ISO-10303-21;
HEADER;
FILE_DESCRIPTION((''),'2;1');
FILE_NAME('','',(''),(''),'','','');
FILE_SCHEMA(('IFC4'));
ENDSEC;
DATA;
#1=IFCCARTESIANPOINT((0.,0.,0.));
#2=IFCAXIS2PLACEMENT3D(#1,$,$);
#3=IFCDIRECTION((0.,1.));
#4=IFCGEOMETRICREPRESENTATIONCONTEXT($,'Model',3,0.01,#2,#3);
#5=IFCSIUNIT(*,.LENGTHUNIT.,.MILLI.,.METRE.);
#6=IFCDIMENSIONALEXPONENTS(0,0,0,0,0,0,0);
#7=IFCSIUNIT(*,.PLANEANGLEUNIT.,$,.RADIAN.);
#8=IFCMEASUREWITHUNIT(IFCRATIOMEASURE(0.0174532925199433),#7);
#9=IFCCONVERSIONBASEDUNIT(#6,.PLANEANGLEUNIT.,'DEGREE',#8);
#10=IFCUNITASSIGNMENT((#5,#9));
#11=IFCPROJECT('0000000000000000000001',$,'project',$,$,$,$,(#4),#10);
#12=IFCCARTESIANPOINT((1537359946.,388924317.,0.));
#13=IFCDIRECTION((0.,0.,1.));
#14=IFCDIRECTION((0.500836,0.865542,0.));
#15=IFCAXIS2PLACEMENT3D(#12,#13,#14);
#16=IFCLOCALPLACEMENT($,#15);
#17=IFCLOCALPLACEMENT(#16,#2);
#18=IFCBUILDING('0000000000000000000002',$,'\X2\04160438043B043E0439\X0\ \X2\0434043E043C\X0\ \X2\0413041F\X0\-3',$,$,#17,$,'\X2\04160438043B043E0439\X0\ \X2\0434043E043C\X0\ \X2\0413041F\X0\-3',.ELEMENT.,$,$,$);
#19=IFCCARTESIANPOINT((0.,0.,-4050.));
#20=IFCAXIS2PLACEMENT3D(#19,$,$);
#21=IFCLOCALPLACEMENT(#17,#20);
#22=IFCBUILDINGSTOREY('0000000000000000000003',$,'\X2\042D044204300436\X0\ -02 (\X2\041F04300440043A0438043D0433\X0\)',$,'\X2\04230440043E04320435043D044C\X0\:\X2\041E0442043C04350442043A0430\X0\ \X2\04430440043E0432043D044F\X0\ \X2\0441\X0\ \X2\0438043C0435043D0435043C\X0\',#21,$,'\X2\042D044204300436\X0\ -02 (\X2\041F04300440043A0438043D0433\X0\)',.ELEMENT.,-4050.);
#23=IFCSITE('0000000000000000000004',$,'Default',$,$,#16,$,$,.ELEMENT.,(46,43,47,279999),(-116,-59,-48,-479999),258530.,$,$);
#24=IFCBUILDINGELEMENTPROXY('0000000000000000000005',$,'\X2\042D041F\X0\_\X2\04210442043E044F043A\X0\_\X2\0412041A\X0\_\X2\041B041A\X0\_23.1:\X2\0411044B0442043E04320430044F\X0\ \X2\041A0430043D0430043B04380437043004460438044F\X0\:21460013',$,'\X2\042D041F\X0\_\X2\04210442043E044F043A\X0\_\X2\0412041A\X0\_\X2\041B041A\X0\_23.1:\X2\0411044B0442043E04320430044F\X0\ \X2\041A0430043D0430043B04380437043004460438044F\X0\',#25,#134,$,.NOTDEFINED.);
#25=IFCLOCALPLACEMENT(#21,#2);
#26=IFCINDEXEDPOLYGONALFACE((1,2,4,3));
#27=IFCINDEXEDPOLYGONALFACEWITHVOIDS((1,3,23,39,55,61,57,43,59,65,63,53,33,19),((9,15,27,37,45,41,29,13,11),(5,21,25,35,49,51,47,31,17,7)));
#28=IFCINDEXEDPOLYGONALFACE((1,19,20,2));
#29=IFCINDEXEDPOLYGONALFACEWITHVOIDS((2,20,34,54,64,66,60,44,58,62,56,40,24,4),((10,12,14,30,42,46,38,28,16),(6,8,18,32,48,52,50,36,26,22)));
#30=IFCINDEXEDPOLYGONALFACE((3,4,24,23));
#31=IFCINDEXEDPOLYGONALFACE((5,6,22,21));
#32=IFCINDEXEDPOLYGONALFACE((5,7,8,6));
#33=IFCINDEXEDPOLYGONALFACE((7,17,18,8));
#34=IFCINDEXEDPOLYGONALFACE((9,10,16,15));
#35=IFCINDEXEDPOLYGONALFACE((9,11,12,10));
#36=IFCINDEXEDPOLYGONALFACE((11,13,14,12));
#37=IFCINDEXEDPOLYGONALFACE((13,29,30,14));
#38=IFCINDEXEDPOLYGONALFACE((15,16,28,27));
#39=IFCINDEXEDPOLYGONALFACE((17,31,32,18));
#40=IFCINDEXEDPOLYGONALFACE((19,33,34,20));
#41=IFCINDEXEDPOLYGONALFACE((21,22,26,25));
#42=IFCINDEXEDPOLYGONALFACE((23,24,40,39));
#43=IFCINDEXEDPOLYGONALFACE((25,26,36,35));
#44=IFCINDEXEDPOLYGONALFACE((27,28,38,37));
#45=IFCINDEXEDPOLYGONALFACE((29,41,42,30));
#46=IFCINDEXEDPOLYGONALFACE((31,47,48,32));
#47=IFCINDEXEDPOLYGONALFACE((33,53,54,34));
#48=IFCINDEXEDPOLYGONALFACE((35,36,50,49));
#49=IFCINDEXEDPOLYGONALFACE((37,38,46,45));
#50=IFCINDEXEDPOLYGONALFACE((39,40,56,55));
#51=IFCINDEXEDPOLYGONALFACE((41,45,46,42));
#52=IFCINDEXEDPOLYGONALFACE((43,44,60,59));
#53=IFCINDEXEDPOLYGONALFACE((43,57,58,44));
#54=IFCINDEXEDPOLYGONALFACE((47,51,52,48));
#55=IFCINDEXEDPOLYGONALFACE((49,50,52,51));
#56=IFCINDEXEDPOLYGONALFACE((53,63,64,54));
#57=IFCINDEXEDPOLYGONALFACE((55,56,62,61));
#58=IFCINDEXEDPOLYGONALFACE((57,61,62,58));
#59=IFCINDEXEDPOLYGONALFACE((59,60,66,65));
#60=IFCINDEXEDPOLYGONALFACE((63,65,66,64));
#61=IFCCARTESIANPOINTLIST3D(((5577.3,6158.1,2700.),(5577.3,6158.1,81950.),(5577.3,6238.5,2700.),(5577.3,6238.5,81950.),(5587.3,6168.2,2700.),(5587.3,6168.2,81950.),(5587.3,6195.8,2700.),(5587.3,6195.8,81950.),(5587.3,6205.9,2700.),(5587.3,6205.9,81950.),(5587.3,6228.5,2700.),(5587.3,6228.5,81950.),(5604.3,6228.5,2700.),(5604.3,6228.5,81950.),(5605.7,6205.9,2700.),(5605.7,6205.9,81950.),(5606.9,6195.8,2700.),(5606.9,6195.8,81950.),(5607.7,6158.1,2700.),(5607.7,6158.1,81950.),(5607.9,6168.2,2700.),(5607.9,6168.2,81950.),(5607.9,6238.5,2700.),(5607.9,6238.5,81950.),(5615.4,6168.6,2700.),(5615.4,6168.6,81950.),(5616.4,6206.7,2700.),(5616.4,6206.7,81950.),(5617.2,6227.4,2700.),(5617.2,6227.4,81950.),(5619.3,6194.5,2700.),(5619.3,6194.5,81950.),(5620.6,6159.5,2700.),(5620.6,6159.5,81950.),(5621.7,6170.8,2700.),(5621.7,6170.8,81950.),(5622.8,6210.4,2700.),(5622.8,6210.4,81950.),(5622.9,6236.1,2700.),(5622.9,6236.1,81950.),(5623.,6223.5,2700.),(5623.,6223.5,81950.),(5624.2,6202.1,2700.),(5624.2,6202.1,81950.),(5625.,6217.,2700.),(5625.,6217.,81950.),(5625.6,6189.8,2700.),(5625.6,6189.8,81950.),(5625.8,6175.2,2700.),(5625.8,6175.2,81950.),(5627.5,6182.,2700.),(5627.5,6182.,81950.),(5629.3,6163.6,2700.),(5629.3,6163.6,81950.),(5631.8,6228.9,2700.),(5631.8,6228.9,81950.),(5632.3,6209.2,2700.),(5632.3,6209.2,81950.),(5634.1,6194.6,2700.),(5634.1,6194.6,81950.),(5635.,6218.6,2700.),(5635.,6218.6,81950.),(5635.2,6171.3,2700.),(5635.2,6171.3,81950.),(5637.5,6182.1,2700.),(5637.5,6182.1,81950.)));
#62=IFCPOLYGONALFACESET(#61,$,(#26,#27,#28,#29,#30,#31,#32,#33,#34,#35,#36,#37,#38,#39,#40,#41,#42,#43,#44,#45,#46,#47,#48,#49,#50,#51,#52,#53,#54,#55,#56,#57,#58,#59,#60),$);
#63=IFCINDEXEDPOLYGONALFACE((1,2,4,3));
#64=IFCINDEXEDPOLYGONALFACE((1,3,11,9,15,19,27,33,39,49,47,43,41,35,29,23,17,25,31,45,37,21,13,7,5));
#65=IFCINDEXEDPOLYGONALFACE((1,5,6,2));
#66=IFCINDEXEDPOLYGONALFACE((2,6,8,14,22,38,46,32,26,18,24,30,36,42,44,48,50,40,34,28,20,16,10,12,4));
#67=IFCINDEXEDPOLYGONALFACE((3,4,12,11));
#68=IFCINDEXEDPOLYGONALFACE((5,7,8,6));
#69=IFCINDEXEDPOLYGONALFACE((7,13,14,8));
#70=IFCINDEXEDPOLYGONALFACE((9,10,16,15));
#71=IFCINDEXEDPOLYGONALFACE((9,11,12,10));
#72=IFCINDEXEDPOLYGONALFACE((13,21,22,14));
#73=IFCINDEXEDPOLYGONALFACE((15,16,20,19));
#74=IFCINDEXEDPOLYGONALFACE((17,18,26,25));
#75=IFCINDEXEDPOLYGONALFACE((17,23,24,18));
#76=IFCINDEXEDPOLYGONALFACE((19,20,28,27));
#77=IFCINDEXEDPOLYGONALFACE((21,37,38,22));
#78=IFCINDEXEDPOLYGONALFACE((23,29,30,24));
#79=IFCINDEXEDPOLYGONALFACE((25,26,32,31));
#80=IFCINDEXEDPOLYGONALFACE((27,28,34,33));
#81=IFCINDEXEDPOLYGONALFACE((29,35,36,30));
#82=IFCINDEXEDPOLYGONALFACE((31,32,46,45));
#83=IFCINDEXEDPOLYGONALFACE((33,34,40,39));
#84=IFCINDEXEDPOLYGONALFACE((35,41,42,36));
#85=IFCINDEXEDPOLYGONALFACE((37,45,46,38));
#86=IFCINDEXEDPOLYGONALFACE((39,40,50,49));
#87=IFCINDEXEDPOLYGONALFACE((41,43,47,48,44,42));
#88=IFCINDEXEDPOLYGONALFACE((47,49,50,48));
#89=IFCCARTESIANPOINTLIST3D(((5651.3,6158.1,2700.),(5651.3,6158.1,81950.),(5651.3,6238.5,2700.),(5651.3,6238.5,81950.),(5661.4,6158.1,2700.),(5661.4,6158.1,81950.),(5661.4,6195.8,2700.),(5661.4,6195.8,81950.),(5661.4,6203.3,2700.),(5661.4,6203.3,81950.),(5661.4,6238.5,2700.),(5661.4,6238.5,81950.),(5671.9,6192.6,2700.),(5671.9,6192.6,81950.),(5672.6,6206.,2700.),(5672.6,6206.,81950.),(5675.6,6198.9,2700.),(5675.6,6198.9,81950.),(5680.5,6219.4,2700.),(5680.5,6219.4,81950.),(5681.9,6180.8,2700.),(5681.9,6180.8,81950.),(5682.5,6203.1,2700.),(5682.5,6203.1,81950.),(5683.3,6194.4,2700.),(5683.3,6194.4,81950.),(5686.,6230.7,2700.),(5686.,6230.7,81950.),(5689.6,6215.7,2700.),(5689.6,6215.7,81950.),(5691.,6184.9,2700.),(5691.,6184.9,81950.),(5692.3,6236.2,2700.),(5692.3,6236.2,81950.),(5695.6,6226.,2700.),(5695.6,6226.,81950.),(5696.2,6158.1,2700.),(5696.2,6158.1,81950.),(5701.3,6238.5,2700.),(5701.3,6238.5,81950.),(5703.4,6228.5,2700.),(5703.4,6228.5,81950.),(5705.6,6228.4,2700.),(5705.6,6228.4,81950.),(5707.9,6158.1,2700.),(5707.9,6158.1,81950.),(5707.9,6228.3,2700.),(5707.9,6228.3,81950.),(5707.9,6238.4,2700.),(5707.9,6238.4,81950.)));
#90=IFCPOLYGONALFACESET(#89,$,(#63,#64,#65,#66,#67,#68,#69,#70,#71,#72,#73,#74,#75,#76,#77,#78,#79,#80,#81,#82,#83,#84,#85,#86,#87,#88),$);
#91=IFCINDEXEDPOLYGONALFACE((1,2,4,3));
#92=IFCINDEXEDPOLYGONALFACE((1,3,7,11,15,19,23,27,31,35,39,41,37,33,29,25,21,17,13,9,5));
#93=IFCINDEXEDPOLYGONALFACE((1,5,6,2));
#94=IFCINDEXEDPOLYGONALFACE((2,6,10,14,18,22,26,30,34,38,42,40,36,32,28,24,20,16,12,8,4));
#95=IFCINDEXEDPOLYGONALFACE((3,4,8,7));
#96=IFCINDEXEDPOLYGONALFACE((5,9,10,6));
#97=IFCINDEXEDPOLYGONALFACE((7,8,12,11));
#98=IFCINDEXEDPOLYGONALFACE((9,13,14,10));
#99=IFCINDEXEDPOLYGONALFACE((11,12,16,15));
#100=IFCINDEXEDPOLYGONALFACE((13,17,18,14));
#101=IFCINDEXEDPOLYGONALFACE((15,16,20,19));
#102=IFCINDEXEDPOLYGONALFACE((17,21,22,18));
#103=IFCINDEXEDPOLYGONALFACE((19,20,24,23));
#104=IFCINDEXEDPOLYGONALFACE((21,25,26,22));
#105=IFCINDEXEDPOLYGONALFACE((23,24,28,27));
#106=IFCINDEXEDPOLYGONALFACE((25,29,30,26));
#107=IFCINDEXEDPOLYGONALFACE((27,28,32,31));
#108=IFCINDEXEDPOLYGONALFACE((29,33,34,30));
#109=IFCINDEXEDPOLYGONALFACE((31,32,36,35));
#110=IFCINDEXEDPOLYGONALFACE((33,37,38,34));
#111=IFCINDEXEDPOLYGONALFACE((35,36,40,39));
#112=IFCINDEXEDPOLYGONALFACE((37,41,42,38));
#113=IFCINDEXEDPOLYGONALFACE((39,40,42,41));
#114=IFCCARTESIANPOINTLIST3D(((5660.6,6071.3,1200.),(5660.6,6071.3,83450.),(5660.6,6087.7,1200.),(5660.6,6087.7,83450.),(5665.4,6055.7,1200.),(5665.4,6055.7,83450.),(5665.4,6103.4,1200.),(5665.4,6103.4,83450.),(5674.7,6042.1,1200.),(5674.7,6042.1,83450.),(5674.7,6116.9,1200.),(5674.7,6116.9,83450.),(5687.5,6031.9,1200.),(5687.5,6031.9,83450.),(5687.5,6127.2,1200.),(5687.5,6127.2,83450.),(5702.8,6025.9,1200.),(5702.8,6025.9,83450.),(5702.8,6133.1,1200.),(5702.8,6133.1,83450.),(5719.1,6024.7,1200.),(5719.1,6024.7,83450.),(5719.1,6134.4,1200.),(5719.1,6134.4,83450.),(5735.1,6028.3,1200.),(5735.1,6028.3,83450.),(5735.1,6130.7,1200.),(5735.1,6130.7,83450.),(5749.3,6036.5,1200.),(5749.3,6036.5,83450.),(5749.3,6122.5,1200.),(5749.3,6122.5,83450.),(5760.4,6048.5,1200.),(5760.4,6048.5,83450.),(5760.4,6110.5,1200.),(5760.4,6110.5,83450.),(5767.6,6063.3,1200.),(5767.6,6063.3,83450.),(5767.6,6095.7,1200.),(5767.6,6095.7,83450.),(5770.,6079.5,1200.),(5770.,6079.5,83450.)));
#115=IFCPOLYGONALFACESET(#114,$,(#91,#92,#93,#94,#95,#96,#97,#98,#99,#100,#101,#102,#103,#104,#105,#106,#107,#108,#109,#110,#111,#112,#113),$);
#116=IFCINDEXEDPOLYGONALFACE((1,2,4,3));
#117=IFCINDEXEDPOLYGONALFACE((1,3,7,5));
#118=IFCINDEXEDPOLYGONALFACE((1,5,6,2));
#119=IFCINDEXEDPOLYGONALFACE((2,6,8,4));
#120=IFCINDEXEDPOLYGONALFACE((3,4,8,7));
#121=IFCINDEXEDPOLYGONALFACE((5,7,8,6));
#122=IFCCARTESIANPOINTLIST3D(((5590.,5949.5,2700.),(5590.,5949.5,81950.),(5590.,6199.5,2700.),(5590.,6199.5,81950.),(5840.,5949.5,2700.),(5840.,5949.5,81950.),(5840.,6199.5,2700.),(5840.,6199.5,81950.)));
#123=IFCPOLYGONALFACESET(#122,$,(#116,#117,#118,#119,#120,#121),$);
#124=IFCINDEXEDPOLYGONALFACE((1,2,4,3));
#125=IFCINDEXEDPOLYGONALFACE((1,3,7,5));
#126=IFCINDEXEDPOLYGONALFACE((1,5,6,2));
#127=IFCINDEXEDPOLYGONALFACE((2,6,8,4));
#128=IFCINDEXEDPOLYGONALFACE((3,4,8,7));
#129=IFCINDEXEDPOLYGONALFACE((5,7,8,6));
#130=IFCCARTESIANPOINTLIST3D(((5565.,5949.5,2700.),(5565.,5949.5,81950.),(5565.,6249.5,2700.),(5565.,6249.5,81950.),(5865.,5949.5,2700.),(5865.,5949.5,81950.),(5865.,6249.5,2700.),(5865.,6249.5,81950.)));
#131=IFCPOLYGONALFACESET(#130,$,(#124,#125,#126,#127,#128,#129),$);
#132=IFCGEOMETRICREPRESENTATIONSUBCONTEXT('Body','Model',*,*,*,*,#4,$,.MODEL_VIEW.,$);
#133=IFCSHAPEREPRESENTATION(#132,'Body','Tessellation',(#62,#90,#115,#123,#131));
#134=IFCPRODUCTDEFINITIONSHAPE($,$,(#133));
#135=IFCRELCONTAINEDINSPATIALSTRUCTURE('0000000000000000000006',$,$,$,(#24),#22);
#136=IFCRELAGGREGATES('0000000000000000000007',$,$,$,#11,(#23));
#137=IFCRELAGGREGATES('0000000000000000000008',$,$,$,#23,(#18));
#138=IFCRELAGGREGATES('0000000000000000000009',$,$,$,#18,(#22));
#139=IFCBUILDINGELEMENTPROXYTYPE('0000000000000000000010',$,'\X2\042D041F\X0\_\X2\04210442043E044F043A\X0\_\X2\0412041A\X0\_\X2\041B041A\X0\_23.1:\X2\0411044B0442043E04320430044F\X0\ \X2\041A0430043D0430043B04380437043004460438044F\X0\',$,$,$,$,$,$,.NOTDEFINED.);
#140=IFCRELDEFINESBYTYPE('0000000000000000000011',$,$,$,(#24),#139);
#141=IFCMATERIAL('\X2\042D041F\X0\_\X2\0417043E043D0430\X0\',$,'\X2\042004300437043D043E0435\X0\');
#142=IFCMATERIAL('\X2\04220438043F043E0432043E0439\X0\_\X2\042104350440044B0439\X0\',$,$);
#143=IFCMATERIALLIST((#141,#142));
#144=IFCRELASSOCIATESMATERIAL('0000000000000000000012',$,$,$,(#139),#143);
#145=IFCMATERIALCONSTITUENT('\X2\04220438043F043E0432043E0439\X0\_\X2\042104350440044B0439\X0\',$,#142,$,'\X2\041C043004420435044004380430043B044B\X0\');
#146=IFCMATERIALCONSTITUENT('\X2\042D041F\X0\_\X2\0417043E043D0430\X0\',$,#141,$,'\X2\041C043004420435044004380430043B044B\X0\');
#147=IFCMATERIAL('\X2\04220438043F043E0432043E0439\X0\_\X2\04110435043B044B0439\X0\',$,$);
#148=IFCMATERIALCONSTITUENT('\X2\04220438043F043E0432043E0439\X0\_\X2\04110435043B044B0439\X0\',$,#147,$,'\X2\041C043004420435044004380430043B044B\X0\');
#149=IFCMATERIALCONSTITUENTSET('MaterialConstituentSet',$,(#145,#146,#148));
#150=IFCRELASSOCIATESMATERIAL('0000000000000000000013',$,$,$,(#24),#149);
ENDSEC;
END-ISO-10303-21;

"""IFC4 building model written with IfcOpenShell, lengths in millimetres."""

from ifc_helpers import new_model, entity, si_unit, converted_unit, direction, frame, frame_2d, origin, place, context, subcontext, project, spatial, polyline, rectangle, circle, outline, extrude, source, transform, mapped, material, material_list, constituent, constituent_set, type_object, type_shapes, element, save


model = new_model("IFC4")

# Units and contexts
model_context = context("Model", 3, precision=0.01, world=origin(), true_north=direction((0.0, 1.0)))
body_context = subcontext(model_context, "Body", "Model", "MODEL_VIEW")
ifc_project = project(units=[si_unit("LENGTHUNIT", "METRE", prefix="MILLI"), converted_unit("PLANEANGLEUNIT", "DEGREE", entity("IfcRatioMeasure", 0.0174532925199433), si_unit("PLANEANGLEUNIT", "RADIAN"), dimensions=[0, 0, 0, 0, 0, 0, 0])], contexts=[model_context])

# Site, building, storey
site_placement = place(None, frame((1537359946.0, 388924317.0, 0.0), z_axis=(0.0, 0.0, 1.0), x_axis=(0.500836, 0.865542, 0.0)))
site = spatial("IfcSite", under=ifc_project, at=site_placement, Name="Default", CompositionType="ELEMENT", RefLatitude=(46, 43, 47, 279999), RefLongitude=(-116, -59, -48, -479999), RefElevation=258530.0)
building_placement = place(site_placement, origin())
building = spatial("IfcBuilding", under=site, at=building_placement, Name="Жилой дом ГП-3", LongName="Жилой дом ГП-3", CompositionType="ELEMENT")
storey_placement = place(building_placement, frame((0.0, 0.0, -4050.0)))
storey = spatial("IfcBuildingStorey", under=building, at=storey_placement, Name="Этаж -02 (Паркинг)", ObjectType="Уровень:Отметка уровня с именем", LongName="Этаж -02 (Паркинг)", CompositionType="ELEMENT", Elevation=-4050.0)

# Building element proxy
ifc_material_1 = material(Name="ЭП_Зона", Category="Разное")
ifc_material_2 = material(Name="Типовой_Белый")
ifc_material_3 = material(Name="Типовой_Серый")
ifc_material_list_1 = material_list([ifc_material_1, ifc_material_3])
building_element_proxy_type_1 = type_object("IfcBuildingElementProxyType", Name="ЭП_Стояк_ВК_ЛК_23.1:Бытовая Канализация", PredefinedType="NOTDEFINED", material=ifc_material_list_1)
shared_shape_1 = source(origin(), body_context, "Body", "SweptSolid", [
    extrude(outline(polyline([(-42.2, -39.0), (-11.8, -39.0), (1.1, -37.6), (9.8, -33.5), (15.7, -25.8), (18.0, -15.0), (14.6, -2.5), (4.7, 5.0), (12.8, 12.1), (15.5, 21.5), (12.3, 31.8), (3.4, 39.0), (-11.6, 41.4), (-42.2, 41.4), (-42.2, -39.0)]), holes=[polyline([(-32.2, 8.8), (-32.2, 31.4), (-15.2, 31.4), (-2.3, 30.3), (3.5, 26.4), (5.5, 19.9), (3.3, 13.3), (-3.1, 9.6), (-13.9, 8.8), (-32.2, 8.8)]), polyline([(-32.2, -28.9), (-32.2, -1.3), (-12.6, -1.3), (-0.2, -2.6), (6.1, -7.3), (8.0, -15.1), (6.3, -21.9), (2.2, -26.3), (-4.1, -28.5), (-11.6, -28.9), (-32.2, -28.9)])]), frame((54.5, -52.4, -1350.0)), (0.0, 0.0, 1.0), 79250.0),
    extrude(outline(polyline([(-32.1, -31.9), (48.3, -31.9), (48.3, -21.8), (10.6, -21.8), (13.8, -11.4), (25.6, -1.3), (48.3, 13.0), (48.3, 24.6), (21.4, 7.7), (12.0, 0.1), (7.4, -7.7), (3.3, -0.7), (-9.3, 6.4), (-19.7, 12.3), (-22.1, 20.2), (-22.0, 22.4), (-22.0, 24.6), (-32.0, 24.6), (-32.1, 18.0), (-29.9, 9.0), (-24.3, 2.8), (-13.1, -2.8), (0.4, -10.6), (3.0, -21.8), (-32.1, -21.8), (-32.1, -31.9)])), frame((118.2, -43.1, -1350.0), z_axis=(0.0, 0.0, 1.0), x_axis=(0.0, -1.0, 0.0)), (0.0, 0.0, 1.0), 79250.0),
    extrude(circle(Radius=55.0, at=frame_2d((0.0, 0.0), x_axis=(1.0, 0.0))), frame((150.0, -170.0, -2850.0)), (0.0, 0.0, 1.0), 82250.0),
    extrude(rectangle(XDim=250.0, YDim=250.0, at=frame_2d((0.0, 0.0), x_axis=(1.0, 0.0))), frame((150.0, -175.0, -1350.0)), (0.0, 0.0, 1.0), 79250.0),
    extrude(rectangle(XDim=300.0, YDim=300.0, at=frame_2d((0.0, 0.0), x_axis=(1.0, 0.0))), frame((150.0, -150.0, -1350.0)), (0.0, 0.0, 1.0), 79250.0),
])
type_shapes(building_element_proxy_type_1, [shared_shape_1])
ifc_constituent_1 = constituent(ifc_material_3, Name="Типовой_Серый", Category="Материалы")
ifc_constituent_2 = constituent(ifc_material_1, Name="ЭП_Зона", Category="Материалы")
ifc_constituent_3 = constituent(ifc_material_2, Name="Типовой_Белый", Category="Материалы")
ifc_constituent_set_1 = constituent_set(constituents=[ifc_constituent_1, ifc_constituent_2, ifc_constituent_3], Name="MaterialConstituentSet")
proxy_1_placement = place(storey_placement, frame((5565.0, 6249.5, 4050.0)))
element("IfcBuildingElementProxy", 1, at=proxy_1_placement, inside=storey, type_object=building_element_proxy_type_1, material=ifc_constituent_set_1, Name="ЭП_Стояк_ВК_ЛК_23.1:Бытовая Канализация:21460013", ObjectType="ЭП_Стояк_ВК_ЛК_23.1:Бытовая Канализация", PredefinedType="NOTDEFINED", context=body_context, shape_type="MappedRepresentation", body=[
    mapped(shared_shape_1, transform((0.0, 0.0, 0.0), scale=1.0)),
])

save(model, "model.ifc")
